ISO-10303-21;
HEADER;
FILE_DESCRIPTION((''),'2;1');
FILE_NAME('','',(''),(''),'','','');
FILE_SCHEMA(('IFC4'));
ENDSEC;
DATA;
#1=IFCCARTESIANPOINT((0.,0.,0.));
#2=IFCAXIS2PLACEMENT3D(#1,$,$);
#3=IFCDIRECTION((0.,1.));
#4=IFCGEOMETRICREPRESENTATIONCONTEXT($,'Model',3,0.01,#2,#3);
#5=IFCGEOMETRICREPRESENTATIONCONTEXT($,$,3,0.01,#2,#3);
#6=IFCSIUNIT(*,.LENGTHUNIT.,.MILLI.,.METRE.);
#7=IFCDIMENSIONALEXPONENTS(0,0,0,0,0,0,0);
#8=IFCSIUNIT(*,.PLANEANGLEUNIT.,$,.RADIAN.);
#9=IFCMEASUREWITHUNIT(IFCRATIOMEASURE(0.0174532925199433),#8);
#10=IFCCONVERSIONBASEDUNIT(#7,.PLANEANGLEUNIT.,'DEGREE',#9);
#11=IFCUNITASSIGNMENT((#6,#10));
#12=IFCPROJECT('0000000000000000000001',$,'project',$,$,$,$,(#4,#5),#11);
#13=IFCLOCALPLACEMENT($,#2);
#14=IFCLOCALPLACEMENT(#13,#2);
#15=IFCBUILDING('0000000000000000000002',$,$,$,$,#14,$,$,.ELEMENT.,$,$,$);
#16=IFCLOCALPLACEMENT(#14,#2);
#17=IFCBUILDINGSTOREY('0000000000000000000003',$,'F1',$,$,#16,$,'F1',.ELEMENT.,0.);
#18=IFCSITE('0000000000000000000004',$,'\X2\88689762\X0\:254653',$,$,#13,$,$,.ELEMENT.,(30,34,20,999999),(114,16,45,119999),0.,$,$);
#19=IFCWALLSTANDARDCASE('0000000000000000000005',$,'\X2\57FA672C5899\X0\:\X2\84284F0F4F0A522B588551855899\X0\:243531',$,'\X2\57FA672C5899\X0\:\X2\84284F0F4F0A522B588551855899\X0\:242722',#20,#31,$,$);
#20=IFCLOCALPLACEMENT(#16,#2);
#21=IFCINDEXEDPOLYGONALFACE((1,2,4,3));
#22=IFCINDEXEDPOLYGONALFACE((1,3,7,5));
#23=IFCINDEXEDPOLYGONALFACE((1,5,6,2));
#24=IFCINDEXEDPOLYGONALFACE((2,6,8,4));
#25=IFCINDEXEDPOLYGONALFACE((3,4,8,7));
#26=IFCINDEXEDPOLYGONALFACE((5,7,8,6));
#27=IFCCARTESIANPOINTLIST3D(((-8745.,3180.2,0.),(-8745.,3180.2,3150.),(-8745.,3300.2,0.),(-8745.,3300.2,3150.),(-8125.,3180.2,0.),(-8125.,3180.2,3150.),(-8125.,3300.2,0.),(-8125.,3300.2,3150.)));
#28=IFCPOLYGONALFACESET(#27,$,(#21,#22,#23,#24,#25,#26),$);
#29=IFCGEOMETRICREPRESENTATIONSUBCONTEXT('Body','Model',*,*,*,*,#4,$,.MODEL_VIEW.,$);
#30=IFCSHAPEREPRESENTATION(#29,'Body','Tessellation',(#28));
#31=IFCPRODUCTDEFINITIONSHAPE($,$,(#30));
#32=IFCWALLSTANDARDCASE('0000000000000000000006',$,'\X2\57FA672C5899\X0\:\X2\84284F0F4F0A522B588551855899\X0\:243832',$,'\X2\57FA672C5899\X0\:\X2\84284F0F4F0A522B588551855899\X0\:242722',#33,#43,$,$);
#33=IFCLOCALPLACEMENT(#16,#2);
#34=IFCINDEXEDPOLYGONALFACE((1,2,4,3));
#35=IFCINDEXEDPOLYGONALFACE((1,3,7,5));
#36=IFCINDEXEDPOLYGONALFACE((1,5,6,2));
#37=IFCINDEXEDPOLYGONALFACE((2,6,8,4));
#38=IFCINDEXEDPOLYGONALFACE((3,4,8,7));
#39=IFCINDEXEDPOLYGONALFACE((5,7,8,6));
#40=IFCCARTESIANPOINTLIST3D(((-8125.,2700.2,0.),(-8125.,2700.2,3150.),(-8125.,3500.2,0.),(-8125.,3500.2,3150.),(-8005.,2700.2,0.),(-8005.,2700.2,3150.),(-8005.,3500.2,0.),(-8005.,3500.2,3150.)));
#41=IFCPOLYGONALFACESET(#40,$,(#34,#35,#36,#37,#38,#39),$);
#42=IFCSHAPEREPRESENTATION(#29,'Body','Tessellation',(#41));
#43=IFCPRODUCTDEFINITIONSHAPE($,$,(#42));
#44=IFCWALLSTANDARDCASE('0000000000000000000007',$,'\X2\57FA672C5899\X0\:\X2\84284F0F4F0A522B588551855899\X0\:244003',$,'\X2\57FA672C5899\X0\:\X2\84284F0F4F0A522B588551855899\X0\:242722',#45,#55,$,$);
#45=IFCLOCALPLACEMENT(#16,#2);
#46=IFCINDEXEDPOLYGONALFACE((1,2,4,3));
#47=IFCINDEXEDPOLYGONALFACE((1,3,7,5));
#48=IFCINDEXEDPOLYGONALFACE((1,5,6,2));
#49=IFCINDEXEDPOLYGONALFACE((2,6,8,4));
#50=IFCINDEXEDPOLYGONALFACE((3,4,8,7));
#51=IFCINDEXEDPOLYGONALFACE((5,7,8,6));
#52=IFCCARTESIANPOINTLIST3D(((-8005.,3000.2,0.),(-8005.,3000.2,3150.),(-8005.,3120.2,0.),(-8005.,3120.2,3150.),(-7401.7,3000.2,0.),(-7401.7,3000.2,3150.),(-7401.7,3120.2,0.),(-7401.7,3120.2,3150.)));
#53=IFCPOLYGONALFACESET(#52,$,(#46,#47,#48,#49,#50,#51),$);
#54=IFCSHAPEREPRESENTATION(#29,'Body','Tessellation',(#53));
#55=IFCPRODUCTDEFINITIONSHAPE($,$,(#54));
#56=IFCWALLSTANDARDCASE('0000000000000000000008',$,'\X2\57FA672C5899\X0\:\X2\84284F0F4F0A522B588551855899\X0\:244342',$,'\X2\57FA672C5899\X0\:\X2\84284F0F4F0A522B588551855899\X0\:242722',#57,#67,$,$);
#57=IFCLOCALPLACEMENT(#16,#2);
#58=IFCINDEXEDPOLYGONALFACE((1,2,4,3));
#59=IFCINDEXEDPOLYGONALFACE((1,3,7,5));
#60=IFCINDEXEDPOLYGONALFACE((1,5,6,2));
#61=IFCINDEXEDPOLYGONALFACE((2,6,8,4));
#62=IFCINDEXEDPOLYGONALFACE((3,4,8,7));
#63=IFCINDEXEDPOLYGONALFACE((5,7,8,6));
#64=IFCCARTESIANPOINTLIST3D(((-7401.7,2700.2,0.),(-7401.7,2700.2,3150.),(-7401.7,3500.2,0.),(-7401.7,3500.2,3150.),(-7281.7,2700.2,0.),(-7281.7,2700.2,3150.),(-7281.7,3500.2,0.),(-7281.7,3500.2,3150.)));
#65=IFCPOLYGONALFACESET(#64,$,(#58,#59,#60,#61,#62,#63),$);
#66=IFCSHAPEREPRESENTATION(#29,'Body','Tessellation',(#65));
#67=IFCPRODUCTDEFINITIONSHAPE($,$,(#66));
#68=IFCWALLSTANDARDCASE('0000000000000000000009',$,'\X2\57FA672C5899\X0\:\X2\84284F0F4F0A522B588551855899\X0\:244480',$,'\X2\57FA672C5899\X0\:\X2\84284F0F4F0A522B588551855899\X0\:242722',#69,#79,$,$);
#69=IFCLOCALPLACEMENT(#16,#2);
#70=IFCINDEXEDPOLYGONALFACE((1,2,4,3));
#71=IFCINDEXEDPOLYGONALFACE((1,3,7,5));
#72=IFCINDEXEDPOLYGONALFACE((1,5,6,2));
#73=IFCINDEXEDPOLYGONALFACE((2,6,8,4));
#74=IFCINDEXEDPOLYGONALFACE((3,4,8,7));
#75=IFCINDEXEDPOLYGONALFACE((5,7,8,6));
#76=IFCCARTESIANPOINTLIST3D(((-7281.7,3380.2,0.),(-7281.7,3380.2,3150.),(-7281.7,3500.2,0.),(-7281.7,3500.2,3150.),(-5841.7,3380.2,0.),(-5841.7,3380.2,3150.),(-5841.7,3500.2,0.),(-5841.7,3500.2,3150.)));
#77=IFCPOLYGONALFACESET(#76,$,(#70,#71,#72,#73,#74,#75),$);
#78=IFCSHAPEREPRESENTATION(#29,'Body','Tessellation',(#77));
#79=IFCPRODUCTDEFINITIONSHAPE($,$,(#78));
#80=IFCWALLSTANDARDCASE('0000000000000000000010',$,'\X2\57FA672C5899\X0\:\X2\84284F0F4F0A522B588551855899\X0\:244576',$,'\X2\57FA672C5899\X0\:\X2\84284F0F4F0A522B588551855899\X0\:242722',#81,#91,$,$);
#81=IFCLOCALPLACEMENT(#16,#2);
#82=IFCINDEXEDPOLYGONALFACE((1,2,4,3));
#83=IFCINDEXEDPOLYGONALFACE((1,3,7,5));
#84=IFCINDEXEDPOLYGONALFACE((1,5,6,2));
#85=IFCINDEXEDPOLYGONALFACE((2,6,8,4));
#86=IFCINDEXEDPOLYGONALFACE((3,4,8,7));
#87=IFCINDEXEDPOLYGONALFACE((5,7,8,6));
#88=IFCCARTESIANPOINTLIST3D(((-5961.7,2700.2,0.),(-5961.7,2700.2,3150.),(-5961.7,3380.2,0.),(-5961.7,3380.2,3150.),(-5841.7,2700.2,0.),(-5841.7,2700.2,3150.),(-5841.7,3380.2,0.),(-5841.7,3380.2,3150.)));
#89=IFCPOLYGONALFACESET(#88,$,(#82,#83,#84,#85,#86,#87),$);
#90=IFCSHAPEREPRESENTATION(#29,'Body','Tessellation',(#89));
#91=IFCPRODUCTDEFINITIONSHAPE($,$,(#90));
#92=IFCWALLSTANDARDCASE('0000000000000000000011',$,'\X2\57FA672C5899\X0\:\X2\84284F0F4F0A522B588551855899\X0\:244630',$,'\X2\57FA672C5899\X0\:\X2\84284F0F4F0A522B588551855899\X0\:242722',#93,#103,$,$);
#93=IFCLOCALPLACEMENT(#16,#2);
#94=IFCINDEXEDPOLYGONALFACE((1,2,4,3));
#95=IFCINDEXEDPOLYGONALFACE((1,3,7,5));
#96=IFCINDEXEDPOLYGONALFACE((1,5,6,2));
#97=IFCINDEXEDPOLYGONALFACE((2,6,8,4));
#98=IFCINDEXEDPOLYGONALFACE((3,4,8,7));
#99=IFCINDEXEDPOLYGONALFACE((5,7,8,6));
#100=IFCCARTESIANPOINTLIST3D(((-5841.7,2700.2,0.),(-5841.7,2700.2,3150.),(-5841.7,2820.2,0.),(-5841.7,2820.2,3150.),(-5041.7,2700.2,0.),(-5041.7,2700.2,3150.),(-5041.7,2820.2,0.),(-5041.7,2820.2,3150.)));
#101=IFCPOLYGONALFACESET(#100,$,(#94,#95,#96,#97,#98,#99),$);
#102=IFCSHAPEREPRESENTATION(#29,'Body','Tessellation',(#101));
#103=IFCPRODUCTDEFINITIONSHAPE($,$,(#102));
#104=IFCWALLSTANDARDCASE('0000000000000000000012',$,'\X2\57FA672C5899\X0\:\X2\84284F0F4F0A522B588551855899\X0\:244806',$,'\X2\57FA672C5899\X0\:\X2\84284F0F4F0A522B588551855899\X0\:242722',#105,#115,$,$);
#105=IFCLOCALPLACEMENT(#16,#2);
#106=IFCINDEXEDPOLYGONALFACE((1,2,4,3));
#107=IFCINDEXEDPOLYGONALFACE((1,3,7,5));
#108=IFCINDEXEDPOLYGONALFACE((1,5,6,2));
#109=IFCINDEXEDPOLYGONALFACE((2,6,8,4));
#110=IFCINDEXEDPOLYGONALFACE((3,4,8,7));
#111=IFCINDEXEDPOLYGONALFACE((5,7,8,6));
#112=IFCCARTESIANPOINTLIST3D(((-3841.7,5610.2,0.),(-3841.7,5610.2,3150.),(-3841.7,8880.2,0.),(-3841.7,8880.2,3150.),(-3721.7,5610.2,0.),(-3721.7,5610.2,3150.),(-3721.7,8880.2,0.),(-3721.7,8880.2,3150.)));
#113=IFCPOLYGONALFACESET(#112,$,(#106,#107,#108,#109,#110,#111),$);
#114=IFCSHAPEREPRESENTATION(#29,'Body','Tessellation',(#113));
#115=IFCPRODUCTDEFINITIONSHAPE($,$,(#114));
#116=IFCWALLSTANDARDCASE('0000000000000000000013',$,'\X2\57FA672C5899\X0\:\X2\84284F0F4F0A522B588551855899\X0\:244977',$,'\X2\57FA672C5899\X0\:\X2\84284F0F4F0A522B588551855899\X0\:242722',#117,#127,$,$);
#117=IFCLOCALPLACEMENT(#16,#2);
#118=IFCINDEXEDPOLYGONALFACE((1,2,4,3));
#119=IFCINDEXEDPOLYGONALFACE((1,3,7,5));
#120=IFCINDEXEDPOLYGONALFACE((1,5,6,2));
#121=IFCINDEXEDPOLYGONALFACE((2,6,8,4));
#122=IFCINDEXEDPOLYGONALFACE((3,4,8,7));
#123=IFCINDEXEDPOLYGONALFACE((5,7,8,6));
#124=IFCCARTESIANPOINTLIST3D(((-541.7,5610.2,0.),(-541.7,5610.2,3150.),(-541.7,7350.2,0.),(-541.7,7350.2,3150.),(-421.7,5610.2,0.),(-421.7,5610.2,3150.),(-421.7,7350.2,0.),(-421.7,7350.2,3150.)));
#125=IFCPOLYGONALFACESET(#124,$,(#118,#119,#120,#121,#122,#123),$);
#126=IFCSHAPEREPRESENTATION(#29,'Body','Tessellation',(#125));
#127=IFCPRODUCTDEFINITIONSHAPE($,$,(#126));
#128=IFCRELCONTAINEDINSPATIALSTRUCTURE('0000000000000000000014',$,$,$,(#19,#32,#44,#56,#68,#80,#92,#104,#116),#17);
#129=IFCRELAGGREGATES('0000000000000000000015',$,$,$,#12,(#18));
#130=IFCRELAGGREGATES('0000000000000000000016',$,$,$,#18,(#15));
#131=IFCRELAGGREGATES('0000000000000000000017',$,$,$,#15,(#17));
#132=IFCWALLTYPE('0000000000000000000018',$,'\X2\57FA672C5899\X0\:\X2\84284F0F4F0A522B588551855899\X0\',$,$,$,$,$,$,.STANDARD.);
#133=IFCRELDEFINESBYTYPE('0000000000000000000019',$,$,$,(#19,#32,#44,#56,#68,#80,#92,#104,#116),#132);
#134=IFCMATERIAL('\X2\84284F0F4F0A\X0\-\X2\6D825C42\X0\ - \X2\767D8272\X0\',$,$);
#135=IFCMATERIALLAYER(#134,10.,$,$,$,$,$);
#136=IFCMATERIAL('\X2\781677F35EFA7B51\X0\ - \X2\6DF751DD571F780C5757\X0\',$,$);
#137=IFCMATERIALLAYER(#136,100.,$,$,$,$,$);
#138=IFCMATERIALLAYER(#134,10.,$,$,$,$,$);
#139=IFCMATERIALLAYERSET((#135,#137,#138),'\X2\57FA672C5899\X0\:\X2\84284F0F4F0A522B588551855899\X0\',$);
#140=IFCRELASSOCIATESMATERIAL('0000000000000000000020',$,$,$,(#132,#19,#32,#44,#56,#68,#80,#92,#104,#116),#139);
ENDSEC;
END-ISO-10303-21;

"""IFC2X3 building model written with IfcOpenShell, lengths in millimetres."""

from ifc_helpers import new_model, entity, si_unit, converted_unit, direction, frame, frame_2d, origin, place, context, subcontext, project, spatial, polyline, rectangle, extrude, clip, bounded_halfspace, material, layer, layer_set, layer_usage, type_object, element, save


model = new_model("IFC2X3")

# Units and contexts
model_context = context("Model", 3, precision=0.01, world=origin(), true_north=direction((0.0, 1.0)))
context_of_model = context(None, 3, precision=0.01, world=origin(), true_north=direction((0.0, 1.0)))
body_context = subcontext(model_context, "Body", "Model", "MODEL_VIEW")
ifc_project = project(units=[si_unit("LENGTHUNIT", "METRE", prefix="MILLI"), converted_unit("PLANEANGLEUNIT", "DEGREE", entity("IfcRatioMeasure", 0.0174532925199433), si_unit("PLANEANGLEUNIT", "RADIAN"), dimensions=[0, 0, 0, 0, 0, 0, 0])], contexts=[model_context, context_of_model])

# Site, building, storey
site_placement = place(None, origin())
site = spatial("IfcSite", under=ifc_project, at=site_placement, Name="表面:254653", CompositionType="ELEMENT", RefLatitude=(30, 34, 20, 999999), RefLongitude=(114, 16, 45, 119999), RefElevation=0.0)
building_placement = place(site_placement, origin())
building = spatial("IfcBuilding", under=site, at=building_placement, CompositionType="ELEMENT")
storey_placement = place(building_placement, origin())
storey = spatial("IfcBuildingStorey", under=building, at=storey_placement, Name="F1", LongName="F1", CompositionType="ELEMENT", Elevation=0.0)

# Shared definitions
ifc_material_1 = material(Name="萨伏伊-涂层 - 白色")
ifc_layer_1 = layer(ifc_material_1, 10.0)
ifc_material_2 = material(Name="砖石建筑 - 混凝土砌块")
ifc_layer_2 = layer(ifc_material_2, 100.0)
ifc_layer_3 = layer(ifc_material_1, 10.0)
ifc_layer_set = layer_set([ifc_layer_1, ifc_layer_2, ifc_layer_3], Name="基本墙:萨伏伊别墅内墙")
wall_type = type_object("IfcWallType", Name="基本墙:萨伏伊别墅内墙", PredefinedType="STANDARD", material=ifc_layer_set)

# Walls
ifc_layer_usage_1 = layer_usage(ifc_layer_set, "AXIS2", "NEGATIVE", 60.0)
wall_1_placement = place(storey_placement, frame((-8745.0, 3240.2, 0.0)))
element("IfcWallStandardCase", 1, at=wall_1_placement, inside=storey, type_object=wall_type, material=ifc_layer_usage_1, Name="基本墙:萨伏伊别墅内墙:243531", ObjectType="基本墙:萨伏伊别墅内墙:242722", context=body_context, shape_type="Clipping", body=[
    clip(extrude(rectangle(XDim=620.0, YDim=120.0, at=frame_2d((310.0, 0.0), x_axis=(-1.0, 0.0))), origin(), (0.0, 0.0, 1.0), 3150.0), bounded_halfspace(frame((0.0, -60.0, 3150.0), z_axis=(0.0, 0.0, -1.0), x_axis=(0.0, -1.0, 0.0)), True, frame((0.0, -60.0, 3150.0)), polyline([(0.0, 0.0), (620.0, 0.0), (620.0, 120.0), (0.0, 120.0), (0.0, 0.0)]))),
])
ifc_layer_usage_2 = layer_usage(ifc_layer_set, "AXIS2", "NEGATIVE", 60.0)
wall_2_placement = place(storey_placement, frame((-8065.0, 3500.2, 0.0), z_axis=(0.0, 0.0, 1.0), x_axis=(0.0, -1.0, 0.0)))
element("IfcWallStandardCase", 2, at=wall_2_placement, inside=storey, type_object=wall_type, material=ifc_layer_usage_2, Name="基本墙:萨伏伊别墅内墙:243832", ObjectType="基本墙:萨伏伊别墅内墙:242722", context=body_context, shape_type="Clipping", body=[
    clip(extrude(rectangle(XDim=800.0, YDim=120.0, at=frame_2d((400.0, 0.0), x_axis=(-1.0, 0.0))), origin(), (0.0, 0.0, 1.0), 3150.0), bounded_halfspace(frame((0.0, -60.0, 3150.0), z_axis=(0.0, 0.0, -1.0), x_axis=(1.0, 0.0, 0.0)), True, frame((0.0, -60.0, 3150.0)), polyline([(0.0, 0.0), (200.0, 0.0), (320.0, 0.0), (800.0, 0.0), (800.0, 120.0), (500.0, 120.0), (380.0, 120.0), (0.0, 120.0), (0.0, 0.0)]))),
])
ifc_layer_usage_3 = layer_usage(ifc_layer_set, "AXIS2", "POSITIVE", -60.0)
wall_3_placement = place(storey_placement, frame((-8005.0, 3060.2, 0.0)))
element("IfcWallStandardCase", 3, at=wall_3_placement, inside=storey, type_object=wall_type, material=ifc_layer_usage_3, Name="基本墙:萨伏伊别墅内墙:244003", ObjectType="基本墙:萨伏伊别墅内墙:242722", context=body_context, shape_type="Clipping", body=[
    clip(extrude(rectangle(XDim=603.3, YDim=120.0, at=frame_2d((301.7, 0.0), x_axis=(-1.0, 0.0))), origin(), (0.0, 0.0, 1.0), 3150.0), bounded_halfspace(frame((0.0, -60.0, 3150.0), z_axis=(0.0, 0.0, -1.0), x_axis=(0.0, -1.0, 0.0)), True, frame((0.0, -60.0, 3150.0)), polyline([(0.0, 0.0), (603.3, 0.0), (603.3, 120.0), (0.0, 120.0), (0.0, 0.0)]))),
])
ifc_layer_usage_4 = layer_usage(ifc_layer_set, "AXIS2", "NEGATIVE", 60.0)
wall_4_placement = place(storey_placement, frame((-7341.7, 3500.2, 0.0), z_axis=(0.0, 0.0, 1.0), x_axis=(0.0, -1.0, 0.0)))
element("IfcWallStandardCase", 4, at=wall_4_placement, inside=storey, type_object=wall_type, material=ifc_layer_usage_4, Name="基本墙:萨伏伊别墅内墙:244342", ObjectType="基本墙:萨伏伊别墅内墙:242722", context=body_context, shape_type="Clipping", body=[
    clip(extrude(rectangle(XDim=800.0, YDim=120.0, at=frame_2d((400.0, 0.0), x_axis=(-1.0, 0.0))), origin(), (0.0, 0.0, 1.0), 3150.0), bounded_halfspace(frame((0.0, -60.0, 3150.0), z_axis=(0.0, 0.0, -1.0), x_axis=(1.0, 0.0, 0.0)), True, frame((0.0, -60.0, 3150.0)), polyline([(0.0, 0.0), (380.0, 0.0), (500.0, 0.0), (800.0, 0.0), (800.0, 120.0), (120.0, 120.0), (0.0, 120.0), (0.0, 0.0)]))),
])
ifc_layer_usage_5 = layer_usage(ifc_layer_set, "AXIS2", "NEGATIVE", 60.0)
wall_5_placement = place(storey_placement, frame((-7281.7, 3440.2, 0.0)))
element("IfcWallStandardCase", 5, at=wall_5_placement, inside=storey, type_object=wall_type, material=ifc_layer_usage_5, Name="基本墙:萨伏伊别墅内墙:244480", ObjectType="基本墙:萨伏伊别墅内墙:242722", context=body_context, shape_type="Clipping", body=[
    clip(extrude(rectangle(XDim=1440.0, YDim=120.0, at=frame_2d((720.0, 0.0), x_axis=(-1.0, 0.0))), origin(), (0.0, 0.0, 1.0), 3150.0), bounded_halfspace(frame((0.0, -60.0, 3150.0), z_axis=(0.0, 0.0, -1.0), x_axis=(0.0, -1.0, 0.0)), True, frame((0.0, -60.0, 3150.0)), polyline([(0.0, 0.0), (1320.0, 0.0), (1440.0, 0.0), (1440.0, 120.0), (0.0, 120.0), (0.0, 0.0)]))),
])
ifc_layer_usage_6 = layer_usage(ifc_layer_set, "AXIS2", "NEGATIVE", 60.0)
wall_6_placement = place(storey_placement, frame((-5901.7, 3380.2, 0.0), z_axis=(0.0, 0.0, 1.0), x_axis=(0.0, -1.0, 0.0)))
element("IfcWallStandardCase", 6, at=wall_6_placement, inside=storey, type_object=wall_type, material=ifc_layer_usage_6, Name="基本墙:萨伏伊别墅内墙:244576", ObjectType="基本墙:萨伏伊别墅内墙:242722", context=body_context, shape_type="Clipping", body=[
    clip(extrude(rectangle(XDim=680.0, YDim=120.0, at=frame_2d((340.0, 0.0), x_axis=(-1.0, 0.0))), origin(), (0.0, 0.0, 1.0), 3150.0), bounded_halfspace(frame((0.0, -60.0, 3150.0), z_axis=(0.0, 0.0, -1.0), x_axis=(1.0, 0.0, 0.0)), True, frame((0.0, -60.0, 3150.0)), polyline([(0.0, 0.0), (680.0, 0.0), (680.0, 120.0), (560.0, 120.0), (0.0, 120.0), (0.0, 0.0)]))),
])
ifc_layer_usage_7 = layer_usage(ifc_layer_set, "AXIS2", "NEGATIVE", 60.0)
wall_7_placement = place(storey_placement, frame((-5841.7, 2760.2, 0.0)))
element("IfcWallStandardCase", 7, at=wall_7_placement, inside=storey, type_object=wall_type, material=ifc_layer_usage_7, Name="基本墙:萨伏伊别墅内墙:244630", ObjectType="基本墙:萨伏伊别墅内墙:242722", context=body_context, shape_type="Clipping", body=[
    clip(extrude(rectangle(XDim=800.0, YDim=120.0, at=frame_2d((400.0, 0.0), x_axis=(-1.0, 0.0))), origin(), (0.0, 0.0, 1.0), 3150.0), bounded_halfspace(frame((0.0, -60.0, 3150.0), z_axis=(0.0, 0.0, -1.0), x_axis=(0.0, -1.0, 0.0)), True, frame((0.0, -60.0, 3150.0)), polyline([(0.0, 0.0), (800.0, 0.0), (800.0, 120.0), (0.0, 120.0), (0.0, 0.0)]))),
])
ifc_layer_usage_8 = layer_usage(ifc_layer_set, "AXIS2", "NEGATIVE", 60.0)
wall_8_placement = place(storey_placement, frame((-3781.7, 5610.2, 0.0), z_axis=(0.0, 0.0, 1.0), x_axis=(0.0, 1.0, 0.0)))
element("IfcWallStandardCase", 8, at=wall_8_placement, inside=storey, type_object=wall_type, material=ifc_layer_usage_8, Name="基本墙:萨伏伊别墅内墙:244806", ObjectType="基本墙:萨伏伊别墅内墙:242722", context=body_context, shape_type="Clipping", body=[
    clip(extrude(rectangle(XDim=3270.0, YDim=120.0, at=frame_2d((1635.0, 0.0), x_axis=(-1.0, 0.0))), origin(), (0.0, 0.0, 1.0), 3150.0), bounded_halfspace(frame((0.0, -60.0, 3150.0), z_axis=(0.0, 0.0, -1.0), x_axis=(-1.0, 0.0, 0.0)), True, frame((0.0, -60.0, 3150.0)), polyline([(0.0, 0.0), (3270.0, 0.0), (3270.0, 120.0), (0.0, 120.0), (0.0, 0.0)]))),
])
ifc_layer_usage_9 = layer_usage(ifc_layer_set, "AXIS2", "NEGATIVE", 60.0)
wall_9_placement = place(storey_placement, frame((-481.7, 5610.2, 0.0), z_axis=(0.0, 0.0, 1.0), x_axis=(0.0, 1.0, 0.0)))
element("IfcWallStandardCase", 9, at=wall_9_placement, inside=storey, type_object=wall_type, material=ifc_layer_usage_9, Name="基本墙:萨伏伊别墅内墙:244977", ObjectType="基本墙:萨伏伊别墅内墙:242722", context=body_context, shape_type="Clipping", body=[
    clip(extrude(rectangle(XDim=1740.0, YDim=120.0, at=frame_2d((870.0, 0.0), x_axis=(-1.0, 0.0))), origin(), (0.0, 0.0, 1.0), 3150.0), bounded_halfspace(frame((0.0, -60.0, 3150.0), z_axis=(0.0, 0.0, -1.0), x_axis=(-1.0, 0.0, 0.0)), True, frame((0.0, -60.0, 3150.0)), polyline([(0.0, 0.0), (1740.0, 0.0), (1740.0, 120.0), (0.0, 120.0), (0.0, 0.0)]))),
])

save(model, "model.ifc")
